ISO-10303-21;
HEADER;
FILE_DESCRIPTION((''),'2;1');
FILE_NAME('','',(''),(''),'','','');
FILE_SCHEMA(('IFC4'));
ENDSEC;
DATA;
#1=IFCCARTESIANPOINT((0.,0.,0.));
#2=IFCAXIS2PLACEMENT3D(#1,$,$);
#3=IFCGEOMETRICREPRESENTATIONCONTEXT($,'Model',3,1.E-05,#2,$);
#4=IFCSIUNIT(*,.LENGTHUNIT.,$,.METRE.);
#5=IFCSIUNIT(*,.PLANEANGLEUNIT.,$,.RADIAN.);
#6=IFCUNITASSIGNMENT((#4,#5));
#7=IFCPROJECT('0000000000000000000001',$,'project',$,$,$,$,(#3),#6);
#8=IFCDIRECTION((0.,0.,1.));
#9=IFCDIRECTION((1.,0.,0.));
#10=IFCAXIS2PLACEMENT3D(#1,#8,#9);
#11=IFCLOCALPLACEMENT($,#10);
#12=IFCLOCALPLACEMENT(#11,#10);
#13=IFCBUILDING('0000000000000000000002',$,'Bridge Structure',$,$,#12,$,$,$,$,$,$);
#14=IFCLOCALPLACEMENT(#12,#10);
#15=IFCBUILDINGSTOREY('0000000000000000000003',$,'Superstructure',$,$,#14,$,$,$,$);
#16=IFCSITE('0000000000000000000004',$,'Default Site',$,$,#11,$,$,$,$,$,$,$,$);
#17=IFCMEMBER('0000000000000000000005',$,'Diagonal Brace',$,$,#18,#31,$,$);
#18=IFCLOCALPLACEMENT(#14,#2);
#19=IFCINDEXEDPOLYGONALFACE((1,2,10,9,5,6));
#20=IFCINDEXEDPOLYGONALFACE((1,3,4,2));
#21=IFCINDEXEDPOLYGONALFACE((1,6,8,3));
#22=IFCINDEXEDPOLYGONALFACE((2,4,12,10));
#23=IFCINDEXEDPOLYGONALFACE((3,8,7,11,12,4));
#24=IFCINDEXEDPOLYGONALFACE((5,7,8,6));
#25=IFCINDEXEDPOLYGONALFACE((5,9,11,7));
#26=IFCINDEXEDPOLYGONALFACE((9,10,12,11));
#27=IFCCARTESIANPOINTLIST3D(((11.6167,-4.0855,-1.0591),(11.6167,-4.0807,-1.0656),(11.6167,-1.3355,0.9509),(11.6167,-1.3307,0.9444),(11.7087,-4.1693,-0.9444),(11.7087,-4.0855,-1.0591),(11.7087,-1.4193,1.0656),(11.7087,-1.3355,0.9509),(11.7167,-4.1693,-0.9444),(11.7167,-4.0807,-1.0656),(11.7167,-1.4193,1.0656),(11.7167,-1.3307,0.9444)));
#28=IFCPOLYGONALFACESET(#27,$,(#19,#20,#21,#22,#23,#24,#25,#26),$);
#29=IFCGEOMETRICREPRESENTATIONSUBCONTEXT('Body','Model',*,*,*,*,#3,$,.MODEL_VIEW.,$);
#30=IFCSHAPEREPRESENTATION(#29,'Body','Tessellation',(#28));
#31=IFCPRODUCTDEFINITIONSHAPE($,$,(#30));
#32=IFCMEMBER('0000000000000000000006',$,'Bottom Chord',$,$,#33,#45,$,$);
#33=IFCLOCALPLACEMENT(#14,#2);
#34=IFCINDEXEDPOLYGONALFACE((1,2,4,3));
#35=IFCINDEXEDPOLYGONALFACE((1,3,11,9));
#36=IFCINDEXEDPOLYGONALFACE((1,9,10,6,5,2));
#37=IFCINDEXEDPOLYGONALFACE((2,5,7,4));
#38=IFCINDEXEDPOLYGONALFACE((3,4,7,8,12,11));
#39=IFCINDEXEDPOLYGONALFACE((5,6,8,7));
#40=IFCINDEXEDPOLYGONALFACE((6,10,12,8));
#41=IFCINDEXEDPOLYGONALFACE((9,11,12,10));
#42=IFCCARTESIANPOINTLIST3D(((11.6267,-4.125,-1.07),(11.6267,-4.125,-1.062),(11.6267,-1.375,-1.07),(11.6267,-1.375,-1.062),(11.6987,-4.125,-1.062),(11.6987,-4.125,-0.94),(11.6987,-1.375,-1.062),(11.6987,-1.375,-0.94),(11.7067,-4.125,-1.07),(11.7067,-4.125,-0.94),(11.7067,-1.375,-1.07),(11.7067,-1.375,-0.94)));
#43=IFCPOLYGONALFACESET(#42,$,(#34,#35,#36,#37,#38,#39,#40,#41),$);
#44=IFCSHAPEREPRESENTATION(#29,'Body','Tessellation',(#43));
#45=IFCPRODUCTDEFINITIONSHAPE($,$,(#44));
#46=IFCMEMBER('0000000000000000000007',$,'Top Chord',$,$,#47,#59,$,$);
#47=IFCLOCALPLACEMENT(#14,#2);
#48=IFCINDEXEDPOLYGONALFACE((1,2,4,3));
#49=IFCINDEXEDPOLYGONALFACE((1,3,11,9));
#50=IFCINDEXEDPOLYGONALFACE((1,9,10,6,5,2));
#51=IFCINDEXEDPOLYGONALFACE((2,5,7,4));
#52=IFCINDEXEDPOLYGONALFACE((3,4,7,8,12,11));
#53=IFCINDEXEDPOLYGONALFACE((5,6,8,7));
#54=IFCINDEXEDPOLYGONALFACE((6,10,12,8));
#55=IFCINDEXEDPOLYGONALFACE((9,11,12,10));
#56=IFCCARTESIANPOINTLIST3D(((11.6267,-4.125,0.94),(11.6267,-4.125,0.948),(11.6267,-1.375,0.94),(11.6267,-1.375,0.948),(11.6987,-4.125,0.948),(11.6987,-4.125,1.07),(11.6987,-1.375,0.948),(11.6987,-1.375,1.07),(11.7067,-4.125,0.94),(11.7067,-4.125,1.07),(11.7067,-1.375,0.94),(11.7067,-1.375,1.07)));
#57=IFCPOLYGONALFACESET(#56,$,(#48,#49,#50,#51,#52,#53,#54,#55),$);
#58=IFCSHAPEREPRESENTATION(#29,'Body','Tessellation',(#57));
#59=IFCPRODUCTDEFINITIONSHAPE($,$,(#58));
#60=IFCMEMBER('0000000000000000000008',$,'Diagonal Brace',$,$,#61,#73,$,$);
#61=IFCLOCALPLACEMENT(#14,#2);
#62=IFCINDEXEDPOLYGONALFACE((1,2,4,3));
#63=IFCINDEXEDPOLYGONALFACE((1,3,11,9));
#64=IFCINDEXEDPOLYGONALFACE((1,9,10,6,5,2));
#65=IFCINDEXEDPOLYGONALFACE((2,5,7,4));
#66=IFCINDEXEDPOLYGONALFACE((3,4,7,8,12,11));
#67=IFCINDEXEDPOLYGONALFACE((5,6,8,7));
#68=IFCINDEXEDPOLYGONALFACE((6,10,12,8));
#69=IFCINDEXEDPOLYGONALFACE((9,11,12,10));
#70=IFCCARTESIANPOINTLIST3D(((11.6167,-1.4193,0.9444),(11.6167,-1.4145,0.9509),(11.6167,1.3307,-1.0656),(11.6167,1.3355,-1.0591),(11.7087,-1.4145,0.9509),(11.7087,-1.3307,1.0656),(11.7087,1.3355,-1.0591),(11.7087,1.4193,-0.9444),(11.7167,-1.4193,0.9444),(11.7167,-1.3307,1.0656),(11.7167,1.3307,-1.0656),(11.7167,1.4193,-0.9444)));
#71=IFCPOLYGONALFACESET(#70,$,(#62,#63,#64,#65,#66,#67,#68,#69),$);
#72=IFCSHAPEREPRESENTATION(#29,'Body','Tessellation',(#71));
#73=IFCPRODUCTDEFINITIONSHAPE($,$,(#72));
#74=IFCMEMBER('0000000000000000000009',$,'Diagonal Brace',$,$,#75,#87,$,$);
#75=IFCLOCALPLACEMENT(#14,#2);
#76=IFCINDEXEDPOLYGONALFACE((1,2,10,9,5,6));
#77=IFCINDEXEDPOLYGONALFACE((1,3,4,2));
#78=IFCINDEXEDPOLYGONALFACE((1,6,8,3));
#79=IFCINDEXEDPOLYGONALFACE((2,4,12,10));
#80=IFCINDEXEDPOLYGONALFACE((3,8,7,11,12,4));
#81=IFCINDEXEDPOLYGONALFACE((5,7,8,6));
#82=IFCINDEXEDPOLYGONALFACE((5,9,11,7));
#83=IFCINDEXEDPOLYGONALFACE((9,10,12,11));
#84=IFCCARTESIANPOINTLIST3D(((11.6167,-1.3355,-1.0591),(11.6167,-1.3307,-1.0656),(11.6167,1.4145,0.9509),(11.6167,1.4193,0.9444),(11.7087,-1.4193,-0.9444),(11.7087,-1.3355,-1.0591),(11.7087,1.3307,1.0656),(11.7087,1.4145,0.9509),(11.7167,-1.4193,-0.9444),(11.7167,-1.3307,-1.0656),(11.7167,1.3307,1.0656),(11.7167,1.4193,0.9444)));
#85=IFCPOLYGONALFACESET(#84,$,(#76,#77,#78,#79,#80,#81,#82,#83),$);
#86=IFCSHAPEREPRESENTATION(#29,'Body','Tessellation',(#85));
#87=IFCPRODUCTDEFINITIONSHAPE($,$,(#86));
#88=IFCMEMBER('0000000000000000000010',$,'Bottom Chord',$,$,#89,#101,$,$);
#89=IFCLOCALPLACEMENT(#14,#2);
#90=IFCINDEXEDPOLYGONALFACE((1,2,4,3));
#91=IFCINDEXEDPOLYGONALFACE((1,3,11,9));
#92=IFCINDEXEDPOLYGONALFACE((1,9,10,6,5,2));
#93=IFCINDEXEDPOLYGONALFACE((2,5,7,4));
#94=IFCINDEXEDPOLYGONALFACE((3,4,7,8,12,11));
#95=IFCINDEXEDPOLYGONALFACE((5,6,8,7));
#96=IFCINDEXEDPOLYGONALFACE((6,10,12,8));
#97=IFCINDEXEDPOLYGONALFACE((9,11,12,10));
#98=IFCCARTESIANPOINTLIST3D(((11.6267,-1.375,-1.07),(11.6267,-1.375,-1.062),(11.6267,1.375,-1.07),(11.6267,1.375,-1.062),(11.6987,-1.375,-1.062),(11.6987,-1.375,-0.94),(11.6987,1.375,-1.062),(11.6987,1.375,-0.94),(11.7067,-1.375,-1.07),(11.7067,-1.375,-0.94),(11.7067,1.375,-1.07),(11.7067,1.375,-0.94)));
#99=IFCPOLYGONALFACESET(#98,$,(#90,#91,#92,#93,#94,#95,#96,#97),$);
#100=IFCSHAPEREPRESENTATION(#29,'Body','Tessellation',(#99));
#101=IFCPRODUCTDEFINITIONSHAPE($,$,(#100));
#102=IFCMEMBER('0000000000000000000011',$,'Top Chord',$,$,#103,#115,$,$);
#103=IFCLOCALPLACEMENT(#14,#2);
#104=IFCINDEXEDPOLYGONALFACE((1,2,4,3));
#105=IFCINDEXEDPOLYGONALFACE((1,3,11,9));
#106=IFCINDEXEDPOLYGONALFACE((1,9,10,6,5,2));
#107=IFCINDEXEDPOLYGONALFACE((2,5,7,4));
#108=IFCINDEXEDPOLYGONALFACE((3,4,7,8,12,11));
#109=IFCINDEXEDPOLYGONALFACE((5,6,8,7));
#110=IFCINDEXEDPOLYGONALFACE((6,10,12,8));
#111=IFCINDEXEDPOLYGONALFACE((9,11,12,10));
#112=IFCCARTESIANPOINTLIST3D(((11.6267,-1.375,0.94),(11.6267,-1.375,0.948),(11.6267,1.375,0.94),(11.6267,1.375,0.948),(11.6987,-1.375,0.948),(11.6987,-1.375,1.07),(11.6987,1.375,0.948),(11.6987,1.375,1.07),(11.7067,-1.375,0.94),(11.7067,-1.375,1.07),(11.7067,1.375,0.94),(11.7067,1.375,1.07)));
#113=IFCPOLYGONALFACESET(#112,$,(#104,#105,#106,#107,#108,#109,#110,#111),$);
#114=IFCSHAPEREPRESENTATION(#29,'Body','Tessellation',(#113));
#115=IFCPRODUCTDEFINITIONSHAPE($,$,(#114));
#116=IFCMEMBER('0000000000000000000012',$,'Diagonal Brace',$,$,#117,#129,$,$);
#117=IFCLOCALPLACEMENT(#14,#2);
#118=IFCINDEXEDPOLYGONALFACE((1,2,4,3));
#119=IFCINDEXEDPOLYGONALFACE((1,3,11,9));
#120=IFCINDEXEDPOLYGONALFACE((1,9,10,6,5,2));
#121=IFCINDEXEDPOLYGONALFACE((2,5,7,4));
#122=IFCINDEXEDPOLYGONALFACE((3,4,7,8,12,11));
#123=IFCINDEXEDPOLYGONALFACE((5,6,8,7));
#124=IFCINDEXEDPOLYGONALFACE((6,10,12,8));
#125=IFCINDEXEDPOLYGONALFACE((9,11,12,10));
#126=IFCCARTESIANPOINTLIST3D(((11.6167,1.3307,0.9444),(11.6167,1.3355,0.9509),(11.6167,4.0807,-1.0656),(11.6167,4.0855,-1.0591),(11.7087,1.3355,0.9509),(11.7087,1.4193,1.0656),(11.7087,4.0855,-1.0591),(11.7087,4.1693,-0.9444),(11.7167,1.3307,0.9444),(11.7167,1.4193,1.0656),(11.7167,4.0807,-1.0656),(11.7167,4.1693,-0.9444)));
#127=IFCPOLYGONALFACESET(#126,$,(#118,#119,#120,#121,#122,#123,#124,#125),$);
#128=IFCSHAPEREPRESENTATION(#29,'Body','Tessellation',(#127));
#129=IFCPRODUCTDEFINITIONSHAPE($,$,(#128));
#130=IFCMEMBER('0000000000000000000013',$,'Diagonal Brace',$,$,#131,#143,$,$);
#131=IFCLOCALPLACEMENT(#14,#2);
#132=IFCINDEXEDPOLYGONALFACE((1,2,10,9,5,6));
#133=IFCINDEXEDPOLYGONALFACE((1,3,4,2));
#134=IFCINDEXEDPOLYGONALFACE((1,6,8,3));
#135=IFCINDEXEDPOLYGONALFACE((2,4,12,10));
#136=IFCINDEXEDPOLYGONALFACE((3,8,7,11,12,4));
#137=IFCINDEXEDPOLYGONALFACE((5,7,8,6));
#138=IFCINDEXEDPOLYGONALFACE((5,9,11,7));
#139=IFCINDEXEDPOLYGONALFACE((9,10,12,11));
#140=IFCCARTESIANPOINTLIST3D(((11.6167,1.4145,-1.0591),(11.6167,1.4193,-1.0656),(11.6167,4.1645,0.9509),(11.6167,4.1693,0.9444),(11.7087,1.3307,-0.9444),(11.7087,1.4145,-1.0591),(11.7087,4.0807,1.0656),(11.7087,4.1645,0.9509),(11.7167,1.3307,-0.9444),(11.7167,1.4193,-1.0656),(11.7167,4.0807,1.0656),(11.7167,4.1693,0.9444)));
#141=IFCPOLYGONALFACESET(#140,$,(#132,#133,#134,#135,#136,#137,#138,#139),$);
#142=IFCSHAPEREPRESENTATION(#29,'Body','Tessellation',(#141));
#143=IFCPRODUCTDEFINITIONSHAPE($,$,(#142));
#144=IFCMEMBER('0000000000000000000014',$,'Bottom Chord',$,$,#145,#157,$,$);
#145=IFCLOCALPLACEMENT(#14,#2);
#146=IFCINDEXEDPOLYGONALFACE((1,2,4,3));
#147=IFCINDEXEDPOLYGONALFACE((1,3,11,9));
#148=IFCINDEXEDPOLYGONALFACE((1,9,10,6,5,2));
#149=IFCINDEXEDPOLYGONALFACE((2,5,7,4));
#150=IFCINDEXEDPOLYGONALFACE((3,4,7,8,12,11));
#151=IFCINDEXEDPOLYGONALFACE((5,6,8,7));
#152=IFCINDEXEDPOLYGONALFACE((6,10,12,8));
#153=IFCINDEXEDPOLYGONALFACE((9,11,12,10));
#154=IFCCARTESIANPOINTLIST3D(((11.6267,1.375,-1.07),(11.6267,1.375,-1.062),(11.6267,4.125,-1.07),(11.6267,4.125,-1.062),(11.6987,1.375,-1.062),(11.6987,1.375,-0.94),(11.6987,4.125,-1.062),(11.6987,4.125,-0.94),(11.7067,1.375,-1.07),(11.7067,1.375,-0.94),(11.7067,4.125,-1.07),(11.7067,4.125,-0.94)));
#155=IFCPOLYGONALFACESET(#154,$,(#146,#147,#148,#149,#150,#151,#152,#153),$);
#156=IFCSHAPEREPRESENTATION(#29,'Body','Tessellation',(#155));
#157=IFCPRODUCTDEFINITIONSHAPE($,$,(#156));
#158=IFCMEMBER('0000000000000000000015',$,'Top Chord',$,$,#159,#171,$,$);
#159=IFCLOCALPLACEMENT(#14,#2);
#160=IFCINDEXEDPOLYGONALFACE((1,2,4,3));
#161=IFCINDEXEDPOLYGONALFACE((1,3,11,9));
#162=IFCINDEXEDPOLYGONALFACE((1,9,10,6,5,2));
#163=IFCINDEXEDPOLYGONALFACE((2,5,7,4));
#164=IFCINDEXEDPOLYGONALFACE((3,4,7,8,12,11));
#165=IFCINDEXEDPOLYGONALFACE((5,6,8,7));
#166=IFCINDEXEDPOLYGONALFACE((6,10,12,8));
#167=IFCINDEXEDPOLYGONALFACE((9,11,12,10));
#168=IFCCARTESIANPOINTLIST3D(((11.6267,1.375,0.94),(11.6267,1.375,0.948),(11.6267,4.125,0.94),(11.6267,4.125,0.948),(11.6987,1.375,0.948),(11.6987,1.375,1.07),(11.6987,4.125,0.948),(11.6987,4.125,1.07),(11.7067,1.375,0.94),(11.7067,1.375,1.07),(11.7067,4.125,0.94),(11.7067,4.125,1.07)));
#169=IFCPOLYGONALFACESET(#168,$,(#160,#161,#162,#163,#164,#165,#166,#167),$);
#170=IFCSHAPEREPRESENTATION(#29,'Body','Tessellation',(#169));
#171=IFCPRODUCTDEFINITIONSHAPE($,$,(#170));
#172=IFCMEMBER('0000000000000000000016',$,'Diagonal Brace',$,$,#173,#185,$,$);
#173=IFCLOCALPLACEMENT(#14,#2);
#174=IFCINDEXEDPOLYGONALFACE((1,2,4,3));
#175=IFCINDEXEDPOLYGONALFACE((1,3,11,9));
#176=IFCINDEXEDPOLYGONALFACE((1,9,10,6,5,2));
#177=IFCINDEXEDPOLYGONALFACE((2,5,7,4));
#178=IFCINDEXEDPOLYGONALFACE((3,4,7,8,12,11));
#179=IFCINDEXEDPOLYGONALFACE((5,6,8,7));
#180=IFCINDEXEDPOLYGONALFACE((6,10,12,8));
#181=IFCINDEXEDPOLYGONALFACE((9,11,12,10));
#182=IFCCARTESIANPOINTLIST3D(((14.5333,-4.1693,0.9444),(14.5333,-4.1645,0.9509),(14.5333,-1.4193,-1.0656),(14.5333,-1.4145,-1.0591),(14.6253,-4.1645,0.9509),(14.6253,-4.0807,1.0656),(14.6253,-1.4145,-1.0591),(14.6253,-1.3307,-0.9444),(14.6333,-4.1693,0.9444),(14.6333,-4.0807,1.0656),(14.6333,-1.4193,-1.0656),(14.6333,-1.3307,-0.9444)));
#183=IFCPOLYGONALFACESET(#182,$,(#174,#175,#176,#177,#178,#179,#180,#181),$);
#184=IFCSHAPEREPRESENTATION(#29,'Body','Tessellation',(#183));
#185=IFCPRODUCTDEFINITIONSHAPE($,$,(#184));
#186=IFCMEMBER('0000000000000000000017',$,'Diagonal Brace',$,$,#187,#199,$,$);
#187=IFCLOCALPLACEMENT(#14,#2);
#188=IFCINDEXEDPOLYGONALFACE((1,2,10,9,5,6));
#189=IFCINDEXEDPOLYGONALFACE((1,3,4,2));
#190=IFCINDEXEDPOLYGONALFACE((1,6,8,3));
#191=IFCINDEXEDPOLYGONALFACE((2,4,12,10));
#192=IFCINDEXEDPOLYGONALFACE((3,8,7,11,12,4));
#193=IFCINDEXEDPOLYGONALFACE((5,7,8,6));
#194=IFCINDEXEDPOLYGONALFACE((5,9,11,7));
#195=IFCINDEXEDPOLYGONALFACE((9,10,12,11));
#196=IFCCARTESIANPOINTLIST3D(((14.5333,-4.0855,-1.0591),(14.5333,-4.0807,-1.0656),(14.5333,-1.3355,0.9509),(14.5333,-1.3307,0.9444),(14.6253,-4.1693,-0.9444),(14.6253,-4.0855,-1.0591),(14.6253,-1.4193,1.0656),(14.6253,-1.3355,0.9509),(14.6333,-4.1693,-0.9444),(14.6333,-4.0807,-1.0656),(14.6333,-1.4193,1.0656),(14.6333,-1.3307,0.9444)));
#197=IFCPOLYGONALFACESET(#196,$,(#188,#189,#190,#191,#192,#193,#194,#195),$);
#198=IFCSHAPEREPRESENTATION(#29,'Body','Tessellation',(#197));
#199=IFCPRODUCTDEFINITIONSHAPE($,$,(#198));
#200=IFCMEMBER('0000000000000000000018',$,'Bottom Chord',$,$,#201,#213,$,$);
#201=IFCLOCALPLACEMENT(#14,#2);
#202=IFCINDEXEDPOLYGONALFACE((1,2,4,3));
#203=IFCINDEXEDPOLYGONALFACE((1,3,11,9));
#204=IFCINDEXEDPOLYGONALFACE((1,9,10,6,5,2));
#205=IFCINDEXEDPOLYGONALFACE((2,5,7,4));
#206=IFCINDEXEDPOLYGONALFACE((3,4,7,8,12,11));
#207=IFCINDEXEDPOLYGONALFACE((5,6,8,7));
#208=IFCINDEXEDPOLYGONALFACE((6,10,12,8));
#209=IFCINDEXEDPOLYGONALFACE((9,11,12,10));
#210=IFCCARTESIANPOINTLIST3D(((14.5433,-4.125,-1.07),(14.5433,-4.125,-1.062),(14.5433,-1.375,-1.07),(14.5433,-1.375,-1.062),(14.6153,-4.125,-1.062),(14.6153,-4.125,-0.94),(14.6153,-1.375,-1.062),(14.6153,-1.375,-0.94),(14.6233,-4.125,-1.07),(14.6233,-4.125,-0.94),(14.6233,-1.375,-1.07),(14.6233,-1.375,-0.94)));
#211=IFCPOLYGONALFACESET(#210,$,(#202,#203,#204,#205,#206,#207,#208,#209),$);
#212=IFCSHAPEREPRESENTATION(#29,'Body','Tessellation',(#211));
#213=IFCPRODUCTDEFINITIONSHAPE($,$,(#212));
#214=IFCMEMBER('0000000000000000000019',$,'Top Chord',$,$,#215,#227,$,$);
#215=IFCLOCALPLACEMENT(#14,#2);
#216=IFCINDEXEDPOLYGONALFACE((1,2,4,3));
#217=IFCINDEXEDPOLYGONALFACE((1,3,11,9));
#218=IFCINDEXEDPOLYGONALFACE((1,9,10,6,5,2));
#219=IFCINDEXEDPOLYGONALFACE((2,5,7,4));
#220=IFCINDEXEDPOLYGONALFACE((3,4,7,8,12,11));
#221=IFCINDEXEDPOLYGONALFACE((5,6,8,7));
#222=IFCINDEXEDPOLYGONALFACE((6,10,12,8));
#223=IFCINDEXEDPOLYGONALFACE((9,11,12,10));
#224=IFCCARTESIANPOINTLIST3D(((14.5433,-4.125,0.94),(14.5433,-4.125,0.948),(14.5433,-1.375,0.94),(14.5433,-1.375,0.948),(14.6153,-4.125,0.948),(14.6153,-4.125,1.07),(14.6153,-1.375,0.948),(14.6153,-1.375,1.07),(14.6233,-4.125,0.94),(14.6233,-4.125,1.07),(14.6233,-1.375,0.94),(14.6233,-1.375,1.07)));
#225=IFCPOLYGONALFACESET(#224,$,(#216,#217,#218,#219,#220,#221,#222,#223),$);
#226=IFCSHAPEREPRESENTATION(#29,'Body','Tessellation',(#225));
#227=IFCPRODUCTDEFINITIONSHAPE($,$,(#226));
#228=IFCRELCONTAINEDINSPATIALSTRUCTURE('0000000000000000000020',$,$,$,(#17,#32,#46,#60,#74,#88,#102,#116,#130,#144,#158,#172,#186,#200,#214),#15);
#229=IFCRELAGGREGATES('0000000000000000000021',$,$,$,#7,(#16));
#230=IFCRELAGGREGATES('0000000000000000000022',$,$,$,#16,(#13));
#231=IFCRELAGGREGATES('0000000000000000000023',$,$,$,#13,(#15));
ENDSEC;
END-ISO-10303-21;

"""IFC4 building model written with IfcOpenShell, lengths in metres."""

from ifc_helpers import new_model, si_unit, frame, origin, origin_with_axes, origin_2d_with_axis, place, context, subcontext, project, spatial, l_section, extrude, element, save


model = new_model("IFC4")

# Units and contexts
model_context = context("Model", 3, precision=1e-05, world=origin())
body_context = subcontext(model_context, "Body", "Model", "MODEL_VIEW")
ifc_project = project(units=[si_unit("LENGTHUNIT", "METRE"), si_unit("PLANEANGLEUNIT", "RADIAN")], contexts=[model_context])

# Site, building, storey
site_placement = place(None, origin_with_axes())
site = spatial("IfcSite", under=ifc_project, at=site_placement, Name="Default Site")
building_placement = place(site_placement, origin_with_axes())
building = spatial("IfcBuilding", under=site, at=building_placement, Name="Bridge Structure")
storey_placement = place(building_placement, origin_with_axes())
storey = spatial("IfcBuildingStorey", under=building, at=storey_placement, Name="Superstructure")

# Members
member_placement = place(storey_placement, frame((11.6667, -4.125, -1.005), z_axis=(0.0, 0.807337, 0.59009), x_axis=(-1.0, 0.0, 0.0)))
element("IfcMember", 1, at=member_placement, inside=storey, Name="Diagonal Brace", context=body_context, shape_type="SweptSolid", body=[
    extrude(l_section(Depth=0.15, Width=0.1, Thickness=0.008, at=origin_2d_with_axis()), origin_with_axes(), (0.0, 0.0, 1.0), 3.4063),
])
for number, where, z_axis, x_axis, name in (
    (2, (11.6667, -4.125, -1.005), (0.0, 1.0, 0.0), (-1.0, 0.0, 0.0), "Bottom Chord"),
    (3, (11.6667, -4.125, 1.005), (0.0, 1.0, 0.0), (-1.0, 0.0, 0.0), "Top Chord"),
):
    element("IfcMember", number, at=place(storey_placement, frame(where, z_axis=z_axis, x_axis=x_axis)), inside=storey, Name=name, context=body_context, shape_type="SweptSolid", body=[
        extrude(l_section(Depth=0.13, Width=0.08, Thickness=0.008, at=origin_2d_with_axis()), origin_with_axes(), (0.0, 0.0, 1.0), 2.75),
    ])
for number, where, z_axis, x_axis, name in (
    (4, (11.6667, -1.375, 1.005), (0.0, 0.807337, -0.59009), (-1.0, 0.0, 0.0), "Diagonal Brace"),
    (5, (11.6667, -1.375, -1.005), (0.0, 0.807337, 0.59009), (-1.0, 0.0, 0.0), "Diagonal Brace"),
):
    element("IfcMember", number, at=place(storey_placement, frame(where, z_axis=z_axis, x_axis=x_axis)), inside=storey, Name=name, context=body_context, shape_type="SweptSolid", body=[
        extrude(l_section(Depth=0.15, Width=0.1, Thickness=0.008, at=origin_2d_with_axis()), origin_with_axes(), (0.0, 0.0, 1.0), 3.4063),
    ])
for number, where, z_axis, x_axis, name in (
    (6, (11.6667, -1.375, -1.005), (0.0, 1.0, 0.0), (-1.0, 0.0, 0.0), "Bottom Chord"),
    (7, (11.6667, -1.375, 1.005), (0.0, 1.0, 0.0), (-1.0, 0.0, 0.0), "Top Chord"),
):
    element("IfcMember", number, at=place(storey_placement, frame(where, z_axis=z_axis, x_axis=x_axis)), inside=storey, Name=name, context=body_context, shape_type="SweptSolid", body=[
        extrude(l_section(Depth=0.13, Width=0.08, Thickness=0.008, at=origin_2d_with_axis()), origin_with_axes(), (0.0, 0.0, 1.0), 2.75),
    ])
for number, where, z_axis, x_axis, name in (
    (8, (11.6667, 1.375, 1.005), (0.0, 0.807337, -0.59009), (-1.0, 0.0, 0.0), "Diagonal Brace"),
    (9, (11.6667, 1.375, -1.005), (0.0, 0.807337, 0.59009), (-1.0, 0.0, 0.0), "Diagonal Brace"),
):
    element("IfcMember", number, at=place(storey_placement, frame(where, z_axis=z_axis, x_axis=x_axis)), inside=storey, Name=name, context=body_context, shape_type="SweptSolid", body=[
        extrude(l_section(Depth=0.15, Width=0.1, Thickness=0.008, at=origin_2d_with_axis()), origin_with_axes(), (0.0, 0.0, 1.0), 3.4063),
    ])
for number, where, z_axis, x_axis, name in (
    (10, (11.6667, 1.375, -1.005), (0.0, 1.0, 0.0), (-1.0, 0.0, 0.0), "Bottom Chord"),
    (11, (11.6667, 1.375, 1.005), (0.0, 1.0, 0.0), (-1.0, 0.0, 0.0), "Top Chord"),
):
    element("IfcMember", number, at=place(storey_placement, frame(where, z_axis=z_axis, x_axis=x_axis)), inside=storey, Name=name, context=body_context, shape_type="SweptSolid", body=[
        extrude(l_section(Depth=0.13, Width=0.08, Thickness=0.008, at=origin_2d_with_axis()), origin_with_axes(), (0.0, 0.0, 1.0), 2.75),
    ])
for number, where, z_axis, x_axis, name in (
    (12, (14.5833, -4.125, 1.005), (0.0, 0.807337, -0.59009), (-1.0, 0.0, 0.0), "Diagonal Brace"),
    (13, (14.5833, -4.125, -1.005), (0.0, 0.807337, 0.59009), (-1.0, 0.0, 0.0), "Diagonal Brace"),
):
    element("IfcMember", number, at=place(storey_placement, frame(where, z_axis=z_axis, x_axis=x_axis)), inside=storey, Name=name, context=body_context, shape_type="SweptSolid", body=[
        extrude(l_section(Depth=0.15, Width=0.1, Thickness=0.008, at=origin_2d_with_axis()), origin_with_axes(), (0.0, 0.0, 1.0), 3.4063),
    ])
for number, where, z_axis, x_axis, name in (
    (14, (14.5833, -4.125, -1.005), (0.0, 1.0, 0.0), (-1.0, 0.0, 0.0), "Bottom Chord"),
    (15, (14.5833, -4.125, 1.005), (0.0, 1.0, 0.0), (-1.0, 0.0, 0.0), "Top Chord"),
):
    element("IfcMember", number, at=place(storey_placement, frame(where, z_axis=z_axis, x_axis=x_axis)), inside=storey, Name=name, context=body_context, shape_type="SweptSolid", body=[
        extrude(l_section(Depth=0.13, Width=0.08, Thickness=0.008, at=origin_2d_with_axis()), origin_with_axes(), (0.0, 0.0, 1.0), 2.75),
    ])

save(model, "model.ifc")
